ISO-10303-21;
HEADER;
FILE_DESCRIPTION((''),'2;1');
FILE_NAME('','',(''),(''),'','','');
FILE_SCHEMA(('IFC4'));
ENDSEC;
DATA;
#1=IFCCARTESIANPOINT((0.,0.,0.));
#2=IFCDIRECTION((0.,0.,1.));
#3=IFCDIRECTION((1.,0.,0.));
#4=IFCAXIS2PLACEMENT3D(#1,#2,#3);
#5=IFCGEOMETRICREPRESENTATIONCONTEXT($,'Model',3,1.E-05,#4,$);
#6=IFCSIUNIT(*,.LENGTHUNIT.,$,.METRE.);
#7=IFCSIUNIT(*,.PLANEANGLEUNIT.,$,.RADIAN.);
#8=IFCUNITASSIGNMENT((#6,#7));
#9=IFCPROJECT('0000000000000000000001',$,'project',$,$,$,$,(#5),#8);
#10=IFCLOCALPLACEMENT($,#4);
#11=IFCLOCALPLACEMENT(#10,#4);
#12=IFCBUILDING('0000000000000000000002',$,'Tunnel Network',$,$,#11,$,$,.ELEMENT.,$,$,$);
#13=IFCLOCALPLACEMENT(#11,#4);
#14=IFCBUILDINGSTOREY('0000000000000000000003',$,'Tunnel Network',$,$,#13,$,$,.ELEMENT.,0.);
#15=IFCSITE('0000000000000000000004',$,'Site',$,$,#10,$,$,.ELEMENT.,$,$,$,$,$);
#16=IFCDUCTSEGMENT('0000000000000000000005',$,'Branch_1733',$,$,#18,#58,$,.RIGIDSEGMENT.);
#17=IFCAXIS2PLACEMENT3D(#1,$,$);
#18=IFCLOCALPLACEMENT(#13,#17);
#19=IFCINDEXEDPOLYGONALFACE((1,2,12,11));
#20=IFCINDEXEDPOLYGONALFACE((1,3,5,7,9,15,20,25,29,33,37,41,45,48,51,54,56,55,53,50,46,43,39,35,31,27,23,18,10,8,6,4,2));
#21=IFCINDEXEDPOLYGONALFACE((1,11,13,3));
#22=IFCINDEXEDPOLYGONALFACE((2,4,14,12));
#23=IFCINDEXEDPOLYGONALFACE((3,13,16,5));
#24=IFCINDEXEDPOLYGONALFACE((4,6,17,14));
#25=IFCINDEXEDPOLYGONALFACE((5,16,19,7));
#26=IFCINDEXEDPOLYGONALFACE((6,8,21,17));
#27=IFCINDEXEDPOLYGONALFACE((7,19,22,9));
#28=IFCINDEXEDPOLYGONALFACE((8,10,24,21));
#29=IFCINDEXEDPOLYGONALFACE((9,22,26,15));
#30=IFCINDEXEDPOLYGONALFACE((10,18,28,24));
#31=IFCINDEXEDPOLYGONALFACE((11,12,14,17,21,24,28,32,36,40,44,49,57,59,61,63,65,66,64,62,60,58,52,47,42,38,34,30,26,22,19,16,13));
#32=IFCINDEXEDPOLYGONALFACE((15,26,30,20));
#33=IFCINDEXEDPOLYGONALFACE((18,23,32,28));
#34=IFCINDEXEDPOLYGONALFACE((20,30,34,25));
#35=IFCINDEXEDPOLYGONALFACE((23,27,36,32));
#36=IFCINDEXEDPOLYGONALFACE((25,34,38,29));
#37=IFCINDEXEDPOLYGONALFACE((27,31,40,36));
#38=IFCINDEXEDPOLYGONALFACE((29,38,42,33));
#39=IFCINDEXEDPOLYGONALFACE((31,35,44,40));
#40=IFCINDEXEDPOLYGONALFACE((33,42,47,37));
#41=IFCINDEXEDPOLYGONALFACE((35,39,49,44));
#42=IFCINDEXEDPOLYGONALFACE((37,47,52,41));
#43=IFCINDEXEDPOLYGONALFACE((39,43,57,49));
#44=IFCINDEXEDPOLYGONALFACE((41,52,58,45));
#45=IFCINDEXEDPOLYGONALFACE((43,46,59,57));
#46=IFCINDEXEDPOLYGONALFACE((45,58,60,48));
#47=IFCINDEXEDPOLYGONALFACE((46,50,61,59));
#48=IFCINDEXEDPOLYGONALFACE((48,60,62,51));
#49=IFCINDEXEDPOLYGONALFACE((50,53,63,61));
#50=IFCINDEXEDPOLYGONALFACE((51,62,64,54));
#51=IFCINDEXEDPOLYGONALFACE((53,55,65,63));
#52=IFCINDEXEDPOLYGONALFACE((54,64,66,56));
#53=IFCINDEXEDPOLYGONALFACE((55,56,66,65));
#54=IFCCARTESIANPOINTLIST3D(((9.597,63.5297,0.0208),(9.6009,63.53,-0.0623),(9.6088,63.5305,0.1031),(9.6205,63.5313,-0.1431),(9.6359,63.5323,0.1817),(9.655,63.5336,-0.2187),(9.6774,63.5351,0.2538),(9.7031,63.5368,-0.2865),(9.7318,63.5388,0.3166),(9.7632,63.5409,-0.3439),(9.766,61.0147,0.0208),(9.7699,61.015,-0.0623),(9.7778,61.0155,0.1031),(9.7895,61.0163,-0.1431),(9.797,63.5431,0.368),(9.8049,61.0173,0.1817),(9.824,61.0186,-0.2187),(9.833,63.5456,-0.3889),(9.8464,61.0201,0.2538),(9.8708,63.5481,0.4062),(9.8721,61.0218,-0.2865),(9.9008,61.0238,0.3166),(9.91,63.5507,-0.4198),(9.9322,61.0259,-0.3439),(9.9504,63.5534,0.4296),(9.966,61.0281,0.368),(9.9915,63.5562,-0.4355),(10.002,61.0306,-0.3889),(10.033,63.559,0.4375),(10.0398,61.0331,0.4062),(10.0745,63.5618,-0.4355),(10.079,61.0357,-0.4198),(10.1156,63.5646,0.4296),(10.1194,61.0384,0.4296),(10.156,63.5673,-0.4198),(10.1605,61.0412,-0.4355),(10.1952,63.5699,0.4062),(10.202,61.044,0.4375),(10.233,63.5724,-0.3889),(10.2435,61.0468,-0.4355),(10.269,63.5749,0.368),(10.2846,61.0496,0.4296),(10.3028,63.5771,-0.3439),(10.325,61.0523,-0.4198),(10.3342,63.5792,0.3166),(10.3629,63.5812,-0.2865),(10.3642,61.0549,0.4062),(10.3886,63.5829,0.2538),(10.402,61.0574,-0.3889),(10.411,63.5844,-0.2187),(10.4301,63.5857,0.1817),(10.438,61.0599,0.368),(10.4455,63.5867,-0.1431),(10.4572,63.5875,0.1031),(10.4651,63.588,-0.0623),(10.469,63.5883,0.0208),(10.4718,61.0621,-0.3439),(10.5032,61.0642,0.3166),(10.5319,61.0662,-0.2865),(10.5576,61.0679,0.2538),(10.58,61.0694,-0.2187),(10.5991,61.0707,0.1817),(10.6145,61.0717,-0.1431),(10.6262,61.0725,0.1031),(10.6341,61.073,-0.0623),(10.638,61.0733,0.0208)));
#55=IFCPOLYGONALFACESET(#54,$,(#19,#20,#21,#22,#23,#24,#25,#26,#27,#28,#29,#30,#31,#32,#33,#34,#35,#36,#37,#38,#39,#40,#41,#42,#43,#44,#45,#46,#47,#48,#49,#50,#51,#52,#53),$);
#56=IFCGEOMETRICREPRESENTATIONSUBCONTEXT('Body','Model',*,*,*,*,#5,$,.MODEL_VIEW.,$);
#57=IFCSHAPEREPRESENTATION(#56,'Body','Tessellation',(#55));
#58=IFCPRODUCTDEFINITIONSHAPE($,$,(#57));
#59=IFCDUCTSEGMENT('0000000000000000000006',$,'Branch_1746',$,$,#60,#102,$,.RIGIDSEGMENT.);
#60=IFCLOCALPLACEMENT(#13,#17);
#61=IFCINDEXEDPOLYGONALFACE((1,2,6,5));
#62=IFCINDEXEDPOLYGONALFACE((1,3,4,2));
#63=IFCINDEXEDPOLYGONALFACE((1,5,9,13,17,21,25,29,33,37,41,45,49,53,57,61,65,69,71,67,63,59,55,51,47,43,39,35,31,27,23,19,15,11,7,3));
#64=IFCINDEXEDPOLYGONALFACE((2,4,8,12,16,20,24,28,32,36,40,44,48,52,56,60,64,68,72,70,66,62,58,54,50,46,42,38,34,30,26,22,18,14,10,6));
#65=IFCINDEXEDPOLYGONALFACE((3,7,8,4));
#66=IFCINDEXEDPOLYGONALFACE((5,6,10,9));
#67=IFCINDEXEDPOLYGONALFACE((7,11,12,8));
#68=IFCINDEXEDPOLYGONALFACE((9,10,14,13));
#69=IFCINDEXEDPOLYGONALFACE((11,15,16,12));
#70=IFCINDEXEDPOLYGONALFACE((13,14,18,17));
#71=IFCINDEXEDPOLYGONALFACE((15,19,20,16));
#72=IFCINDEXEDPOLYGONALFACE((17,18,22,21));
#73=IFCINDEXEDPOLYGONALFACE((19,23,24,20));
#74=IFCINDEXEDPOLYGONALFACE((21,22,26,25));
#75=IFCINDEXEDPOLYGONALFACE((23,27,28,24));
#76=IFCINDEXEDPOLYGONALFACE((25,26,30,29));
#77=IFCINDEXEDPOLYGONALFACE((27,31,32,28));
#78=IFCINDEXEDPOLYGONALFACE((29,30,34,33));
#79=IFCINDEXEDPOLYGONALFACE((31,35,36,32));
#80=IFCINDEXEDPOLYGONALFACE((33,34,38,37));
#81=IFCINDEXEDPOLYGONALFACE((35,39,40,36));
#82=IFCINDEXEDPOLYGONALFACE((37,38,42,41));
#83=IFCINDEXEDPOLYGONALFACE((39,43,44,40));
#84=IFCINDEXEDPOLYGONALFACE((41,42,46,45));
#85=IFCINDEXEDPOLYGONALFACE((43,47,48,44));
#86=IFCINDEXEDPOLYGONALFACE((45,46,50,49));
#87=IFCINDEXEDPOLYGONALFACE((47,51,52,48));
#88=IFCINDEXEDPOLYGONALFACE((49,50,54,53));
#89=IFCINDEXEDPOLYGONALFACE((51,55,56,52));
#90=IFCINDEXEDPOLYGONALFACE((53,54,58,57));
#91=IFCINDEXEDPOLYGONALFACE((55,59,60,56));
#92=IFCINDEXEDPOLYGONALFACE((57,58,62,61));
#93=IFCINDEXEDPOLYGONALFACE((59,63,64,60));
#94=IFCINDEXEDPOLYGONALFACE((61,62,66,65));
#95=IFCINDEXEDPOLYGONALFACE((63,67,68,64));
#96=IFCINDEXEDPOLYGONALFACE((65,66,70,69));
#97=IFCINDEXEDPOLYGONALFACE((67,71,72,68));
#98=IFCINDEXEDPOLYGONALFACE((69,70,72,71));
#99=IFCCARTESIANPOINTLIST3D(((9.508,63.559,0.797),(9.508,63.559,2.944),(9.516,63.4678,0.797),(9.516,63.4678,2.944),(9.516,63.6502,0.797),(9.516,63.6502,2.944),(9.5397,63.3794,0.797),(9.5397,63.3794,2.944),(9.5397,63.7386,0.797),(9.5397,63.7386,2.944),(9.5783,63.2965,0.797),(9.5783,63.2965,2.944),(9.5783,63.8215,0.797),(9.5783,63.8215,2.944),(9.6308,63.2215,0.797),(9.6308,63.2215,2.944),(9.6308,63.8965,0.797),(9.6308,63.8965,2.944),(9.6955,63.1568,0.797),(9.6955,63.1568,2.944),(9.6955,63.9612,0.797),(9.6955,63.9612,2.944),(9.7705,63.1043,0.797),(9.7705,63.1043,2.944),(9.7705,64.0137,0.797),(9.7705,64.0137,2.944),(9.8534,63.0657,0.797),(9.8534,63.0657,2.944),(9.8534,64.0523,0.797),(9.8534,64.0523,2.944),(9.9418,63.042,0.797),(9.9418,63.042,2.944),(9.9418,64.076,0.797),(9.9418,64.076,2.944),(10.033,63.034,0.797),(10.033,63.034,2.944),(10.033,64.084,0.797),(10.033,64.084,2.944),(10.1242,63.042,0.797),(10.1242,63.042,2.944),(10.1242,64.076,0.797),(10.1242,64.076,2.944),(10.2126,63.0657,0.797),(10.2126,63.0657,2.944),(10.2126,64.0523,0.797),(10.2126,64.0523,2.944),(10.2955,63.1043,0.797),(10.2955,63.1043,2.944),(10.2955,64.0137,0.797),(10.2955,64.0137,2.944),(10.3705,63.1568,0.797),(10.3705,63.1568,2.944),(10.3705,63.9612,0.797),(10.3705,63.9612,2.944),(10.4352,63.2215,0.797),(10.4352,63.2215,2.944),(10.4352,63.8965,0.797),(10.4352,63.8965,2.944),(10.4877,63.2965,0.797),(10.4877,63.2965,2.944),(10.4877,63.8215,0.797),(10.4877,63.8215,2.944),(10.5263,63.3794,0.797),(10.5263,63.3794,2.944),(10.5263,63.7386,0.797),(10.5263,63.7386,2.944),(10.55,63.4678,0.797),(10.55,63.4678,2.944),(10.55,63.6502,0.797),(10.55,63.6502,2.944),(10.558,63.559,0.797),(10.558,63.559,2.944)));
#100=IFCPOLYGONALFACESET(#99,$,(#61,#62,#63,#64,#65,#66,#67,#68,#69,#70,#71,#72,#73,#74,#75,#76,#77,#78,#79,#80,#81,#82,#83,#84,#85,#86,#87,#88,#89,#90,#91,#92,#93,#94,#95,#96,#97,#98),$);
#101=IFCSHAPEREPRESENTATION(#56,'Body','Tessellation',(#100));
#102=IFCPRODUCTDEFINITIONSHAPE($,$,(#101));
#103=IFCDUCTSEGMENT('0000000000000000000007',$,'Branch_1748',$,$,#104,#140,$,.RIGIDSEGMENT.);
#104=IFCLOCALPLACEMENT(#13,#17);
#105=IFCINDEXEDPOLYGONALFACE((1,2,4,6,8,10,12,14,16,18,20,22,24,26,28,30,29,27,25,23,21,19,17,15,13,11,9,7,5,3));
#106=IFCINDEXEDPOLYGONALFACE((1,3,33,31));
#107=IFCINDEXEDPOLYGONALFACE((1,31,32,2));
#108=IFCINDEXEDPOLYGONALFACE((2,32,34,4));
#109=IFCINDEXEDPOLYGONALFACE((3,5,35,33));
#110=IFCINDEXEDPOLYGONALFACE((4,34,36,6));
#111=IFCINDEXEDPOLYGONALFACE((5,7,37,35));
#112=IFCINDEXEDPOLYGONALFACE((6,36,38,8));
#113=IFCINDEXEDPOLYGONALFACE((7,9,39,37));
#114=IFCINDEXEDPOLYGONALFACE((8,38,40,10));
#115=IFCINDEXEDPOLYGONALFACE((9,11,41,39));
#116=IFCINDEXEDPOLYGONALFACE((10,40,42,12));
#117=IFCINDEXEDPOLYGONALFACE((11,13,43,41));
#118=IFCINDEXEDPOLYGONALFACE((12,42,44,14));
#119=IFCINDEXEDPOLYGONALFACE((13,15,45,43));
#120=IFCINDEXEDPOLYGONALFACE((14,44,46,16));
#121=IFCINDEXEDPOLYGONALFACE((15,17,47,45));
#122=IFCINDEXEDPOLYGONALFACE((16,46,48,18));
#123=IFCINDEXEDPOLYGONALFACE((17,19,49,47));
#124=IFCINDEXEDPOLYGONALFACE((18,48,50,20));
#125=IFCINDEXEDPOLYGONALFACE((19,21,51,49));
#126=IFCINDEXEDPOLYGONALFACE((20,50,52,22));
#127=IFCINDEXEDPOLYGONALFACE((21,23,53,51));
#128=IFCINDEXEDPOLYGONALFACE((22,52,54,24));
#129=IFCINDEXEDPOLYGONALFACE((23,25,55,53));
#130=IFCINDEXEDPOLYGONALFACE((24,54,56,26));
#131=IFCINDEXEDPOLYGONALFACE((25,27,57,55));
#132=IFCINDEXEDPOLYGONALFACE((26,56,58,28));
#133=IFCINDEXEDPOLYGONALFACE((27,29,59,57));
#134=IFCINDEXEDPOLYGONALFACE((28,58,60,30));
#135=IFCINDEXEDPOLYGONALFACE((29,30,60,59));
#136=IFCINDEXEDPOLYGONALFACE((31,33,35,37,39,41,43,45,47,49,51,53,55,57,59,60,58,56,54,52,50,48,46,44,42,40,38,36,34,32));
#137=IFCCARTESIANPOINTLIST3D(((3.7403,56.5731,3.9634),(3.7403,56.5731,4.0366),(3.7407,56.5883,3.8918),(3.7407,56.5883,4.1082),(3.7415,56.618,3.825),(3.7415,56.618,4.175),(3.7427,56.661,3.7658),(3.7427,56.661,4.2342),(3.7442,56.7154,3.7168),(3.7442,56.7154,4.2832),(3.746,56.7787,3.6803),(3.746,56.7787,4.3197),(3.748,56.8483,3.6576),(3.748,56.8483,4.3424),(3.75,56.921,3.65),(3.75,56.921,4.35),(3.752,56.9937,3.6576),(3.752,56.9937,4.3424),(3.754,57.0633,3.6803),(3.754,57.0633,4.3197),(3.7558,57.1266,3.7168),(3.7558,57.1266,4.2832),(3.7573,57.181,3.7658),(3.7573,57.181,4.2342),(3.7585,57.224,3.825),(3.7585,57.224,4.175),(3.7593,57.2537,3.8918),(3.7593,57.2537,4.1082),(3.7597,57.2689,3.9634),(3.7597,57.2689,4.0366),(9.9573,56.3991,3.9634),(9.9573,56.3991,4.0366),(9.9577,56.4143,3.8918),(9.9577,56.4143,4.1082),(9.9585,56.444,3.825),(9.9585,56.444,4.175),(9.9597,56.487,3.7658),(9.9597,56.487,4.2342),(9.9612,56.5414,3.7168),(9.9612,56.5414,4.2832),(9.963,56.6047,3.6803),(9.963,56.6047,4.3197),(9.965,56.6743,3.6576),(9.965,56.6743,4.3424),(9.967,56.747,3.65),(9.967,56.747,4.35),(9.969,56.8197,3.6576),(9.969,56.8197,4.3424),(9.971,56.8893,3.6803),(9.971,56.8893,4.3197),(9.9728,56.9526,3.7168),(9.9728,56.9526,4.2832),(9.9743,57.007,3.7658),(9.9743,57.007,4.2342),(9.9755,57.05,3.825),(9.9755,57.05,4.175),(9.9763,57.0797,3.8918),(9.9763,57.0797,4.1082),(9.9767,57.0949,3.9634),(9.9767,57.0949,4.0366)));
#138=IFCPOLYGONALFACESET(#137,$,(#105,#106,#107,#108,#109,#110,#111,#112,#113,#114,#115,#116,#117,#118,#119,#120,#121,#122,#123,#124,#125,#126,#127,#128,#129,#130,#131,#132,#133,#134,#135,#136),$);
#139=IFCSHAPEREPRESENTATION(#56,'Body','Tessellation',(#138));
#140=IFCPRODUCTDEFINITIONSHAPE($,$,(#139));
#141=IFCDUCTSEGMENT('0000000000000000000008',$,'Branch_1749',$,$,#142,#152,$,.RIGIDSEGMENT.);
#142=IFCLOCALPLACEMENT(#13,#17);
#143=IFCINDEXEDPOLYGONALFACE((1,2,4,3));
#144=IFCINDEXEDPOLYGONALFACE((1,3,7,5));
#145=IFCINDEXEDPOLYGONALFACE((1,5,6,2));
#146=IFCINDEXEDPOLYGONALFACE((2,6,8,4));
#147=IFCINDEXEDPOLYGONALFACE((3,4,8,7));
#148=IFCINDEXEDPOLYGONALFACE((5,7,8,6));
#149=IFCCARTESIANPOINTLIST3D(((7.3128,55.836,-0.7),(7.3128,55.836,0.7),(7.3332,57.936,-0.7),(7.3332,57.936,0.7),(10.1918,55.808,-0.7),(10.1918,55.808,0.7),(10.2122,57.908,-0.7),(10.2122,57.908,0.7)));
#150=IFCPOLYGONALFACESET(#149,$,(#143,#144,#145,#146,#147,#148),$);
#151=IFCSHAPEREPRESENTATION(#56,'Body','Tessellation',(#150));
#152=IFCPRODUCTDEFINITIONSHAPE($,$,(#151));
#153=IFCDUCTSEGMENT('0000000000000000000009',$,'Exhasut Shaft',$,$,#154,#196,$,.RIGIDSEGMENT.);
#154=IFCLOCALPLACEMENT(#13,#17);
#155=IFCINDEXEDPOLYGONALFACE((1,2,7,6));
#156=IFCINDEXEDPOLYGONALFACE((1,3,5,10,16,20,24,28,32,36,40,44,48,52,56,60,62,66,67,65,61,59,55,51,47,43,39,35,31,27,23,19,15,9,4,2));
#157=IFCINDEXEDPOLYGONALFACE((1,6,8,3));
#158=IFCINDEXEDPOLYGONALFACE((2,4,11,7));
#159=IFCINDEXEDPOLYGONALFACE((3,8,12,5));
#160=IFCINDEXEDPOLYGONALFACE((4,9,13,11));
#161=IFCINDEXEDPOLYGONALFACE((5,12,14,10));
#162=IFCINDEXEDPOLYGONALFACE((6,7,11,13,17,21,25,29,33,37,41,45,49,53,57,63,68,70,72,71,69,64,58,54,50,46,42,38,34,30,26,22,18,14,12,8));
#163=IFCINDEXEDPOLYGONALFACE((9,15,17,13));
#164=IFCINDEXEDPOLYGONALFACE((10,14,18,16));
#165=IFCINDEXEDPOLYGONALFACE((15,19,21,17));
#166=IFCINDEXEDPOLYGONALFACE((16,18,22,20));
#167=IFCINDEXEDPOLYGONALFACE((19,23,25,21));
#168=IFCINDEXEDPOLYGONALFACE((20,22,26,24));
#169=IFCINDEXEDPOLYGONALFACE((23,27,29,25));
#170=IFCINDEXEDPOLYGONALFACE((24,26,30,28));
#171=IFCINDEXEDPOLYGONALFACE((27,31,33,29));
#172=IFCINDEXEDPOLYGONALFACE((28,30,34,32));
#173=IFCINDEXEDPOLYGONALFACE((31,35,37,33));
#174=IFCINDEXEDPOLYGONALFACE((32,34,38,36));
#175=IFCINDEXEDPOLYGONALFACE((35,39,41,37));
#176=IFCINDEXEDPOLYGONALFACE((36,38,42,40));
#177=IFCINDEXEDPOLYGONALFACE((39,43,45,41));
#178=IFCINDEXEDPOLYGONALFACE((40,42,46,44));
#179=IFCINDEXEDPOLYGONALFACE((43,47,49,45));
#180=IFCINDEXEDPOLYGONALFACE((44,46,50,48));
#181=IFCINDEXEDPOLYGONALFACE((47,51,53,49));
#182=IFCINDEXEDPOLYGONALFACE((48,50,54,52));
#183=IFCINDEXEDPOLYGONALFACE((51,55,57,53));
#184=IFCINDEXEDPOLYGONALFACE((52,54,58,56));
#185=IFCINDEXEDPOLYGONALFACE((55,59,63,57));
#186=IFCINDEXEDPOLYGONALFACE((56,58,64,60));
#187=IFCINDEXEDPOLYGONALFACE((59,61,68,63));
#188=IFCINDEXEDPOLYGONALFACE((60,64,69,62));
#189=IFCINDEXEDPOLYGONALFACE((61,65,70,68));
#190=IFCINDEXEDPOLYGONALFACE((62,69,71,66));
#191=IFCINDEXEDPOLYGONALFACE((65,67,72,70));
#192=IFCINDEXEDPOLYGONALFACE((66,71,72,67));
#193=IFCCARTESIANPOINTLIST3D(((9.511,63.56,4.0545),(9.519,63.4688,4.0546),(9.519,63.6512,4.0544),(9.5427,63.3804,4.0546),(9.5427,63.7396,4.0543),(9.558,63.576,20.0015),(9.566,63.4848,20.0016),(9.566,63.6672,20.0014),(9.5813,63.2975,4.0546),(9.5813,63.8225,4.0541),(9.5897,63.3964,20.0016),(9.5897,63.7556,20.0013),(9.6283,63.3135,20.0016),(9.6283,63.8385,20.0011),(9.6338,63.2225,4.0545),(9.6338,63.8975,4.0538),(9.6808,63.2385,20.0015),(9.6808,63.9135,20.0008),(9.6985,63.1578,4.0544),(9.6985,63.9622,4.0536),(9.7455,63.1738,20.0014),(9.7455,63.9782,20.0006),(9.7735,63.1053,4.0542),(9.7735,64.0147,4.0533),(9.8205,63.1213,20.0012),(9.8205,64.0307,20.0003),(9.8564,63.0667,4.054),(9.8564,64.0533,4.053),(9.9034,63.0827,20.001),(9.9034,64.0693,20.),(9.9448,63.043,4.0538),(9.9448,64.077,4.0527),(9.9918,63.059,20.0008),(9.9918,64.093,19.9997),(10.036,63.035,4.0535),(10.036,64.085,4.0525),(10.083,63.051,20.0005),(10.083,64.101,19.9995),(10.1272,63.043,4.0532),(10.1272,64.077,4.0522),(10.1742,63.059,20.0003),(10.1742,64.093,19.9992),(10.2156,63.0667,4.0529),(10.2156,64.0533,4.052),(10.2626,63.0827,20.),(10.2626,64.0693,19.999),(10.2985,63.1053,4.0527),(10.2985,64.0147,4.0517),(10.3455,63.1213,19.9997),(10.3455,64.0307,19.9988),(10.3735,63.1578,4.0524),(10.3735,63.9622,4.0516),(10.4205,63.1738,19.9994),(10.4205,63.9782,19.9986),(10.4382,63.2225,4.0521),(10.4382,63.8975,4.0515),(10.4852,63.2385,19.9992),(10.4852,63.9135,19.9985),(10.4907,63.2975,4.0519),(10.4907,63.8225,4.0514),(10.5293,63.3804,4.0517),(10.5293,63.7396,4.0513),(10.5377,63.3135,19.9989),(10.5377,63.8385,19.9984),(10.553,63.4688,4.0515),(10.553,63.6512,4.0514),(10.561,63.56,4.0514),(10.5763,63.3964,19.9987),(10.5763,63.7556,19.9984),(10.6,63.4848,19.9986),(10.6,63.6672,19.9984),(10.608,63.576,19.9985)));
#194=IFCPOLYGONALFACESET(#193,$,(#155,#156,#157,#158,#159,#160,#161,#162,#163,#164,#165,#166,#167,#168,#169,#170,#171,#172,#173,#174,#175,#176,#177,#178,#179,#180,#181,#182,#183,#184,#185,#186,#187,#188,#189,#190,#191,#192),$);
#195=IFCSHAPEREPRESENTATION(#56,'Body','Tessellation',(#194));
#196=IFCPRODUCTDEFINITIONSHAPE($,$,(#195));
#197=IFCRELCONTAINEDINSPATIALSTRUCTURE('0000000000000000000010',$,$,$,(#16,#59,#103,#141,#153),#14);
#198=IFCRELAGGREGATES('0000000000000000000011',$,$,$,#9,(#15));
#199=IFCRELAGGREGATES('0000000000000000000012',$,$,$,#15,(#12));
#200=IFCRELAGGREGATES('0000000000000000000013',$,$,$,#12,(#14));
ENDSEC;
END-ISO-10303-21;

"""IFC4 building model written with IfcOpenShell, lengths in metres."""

from ifc_helpers import new_model, si_unit, frame, origin_with_axes, origin_2d_with_axis, place, context, subcontext, project, spatial, rectangle, circle, extrude, element, save


model = new_model("IFC4")

# Units and contexts
model_context = context("Model", 3, precision=1e-05, world=origin_with_axes())
body_context = subcontext(model_context, "Body", "Model", "MODEL_VIEW")
ifc_project = project(units=[si_unit("LENGTHUNIT", "METRE"), si_unit("PLANEANGLEUNIT", "RADIAN")], contexts=[model_context])

# Site, building, storey
site_placement = place(None, origin_with_axes())
site = spatial("IfcSite", under=ifc_project, at=site_placement, Name="Site", CompositionType="ELEMENT")
building_placement = place(site_placement, origin_with_axes())
building = spatial("IfcBuilding", under=site, at=building_placement, Name="Tunnel Network", CompositionType="ELEMENT")
storey_placement = place(building_placement, origin_with_axes())
storey = spatial("IfcBuildingStorey", under=building, at=storey_placement, Name="Tunnel Network", CompositionType="ELEMENT", Elevation=0.0)

# Duct segments
duct_segment_1_placement = place(storey_placement, frame((10.202, 61.044, 0.0), z_axis=(-0.067045, 0.99775, 0.0), x_axis=(0.0, 0.0, 1.0)))
element("IfcDuctSegment", 1, at=duct_segment_1_placement, inside=storey, Name="Branch_1733", PredefinedType="RIGIDSEGMENT", context=body_context, shape_type="SweptSolid", body=[
    extrude(circle(Radius=0.4375, at=origin_2d_with_axis()), origin_with_axes(), (0.0, 0.0, 1.0), 2.5207),
])
duct_segment_2_placement = place(storey_placement, frame((10.033, 63.559, 0.797), z_axis=(0.0, 0.0, 1.0), x_axis=(1.0, 0.0, 0.0)))
element("IfcDuctSegment", 2, at=duct_segment_2_placement, inside=storey, Name="Branch_1746", PredefinedType="RIGIDSEGMENT", context=body_context, shape_type="SweptSolid", body=[
    extrude(circle(Radius=0.525, at=origin_2d_with_axis()), origin_with_axes(), (0.0, 0.0, 1.0), 2.147),
])
duct_segment_3_placement = place(storey_placement, frame((3.75, 56.921, 4.0), z_axis=(0.999609, -0.027977, 0.0), x_axis=(0.0, 0.0, 1.0)))
element("IfcDuctSegment", 3, at=duct_segment_3_placement, inside=storey, Name="Branch_1748", PredefinedType="RIGIDSEGMENT", context=body_context, shape_type="SweptSolid", body=[
    extrude(circle(Radius=0.35, at=origin_2d_with_axis()), origin_with_axes(), (0.0, 0.0, 1.0), 6.2194),
])
duct_segment_4_placement = place(storey_placement, frame((7.323, 56.886, 0.0), z_axis=(0.999953, -0.009725, 0.0), x_axis=(0.0, 0.0, 1.0)))
element("IfcDuctSegment", 4, at=duct_segment_4_placement, inside=storey, Name="Branch_1749", PredefinedType="RIGIDSEGMENT", context=body_context, shape_type="SweptSolid", body=[
    extrude(rectangle(XDim=1.4, YDim=2.1, at=origin_2d_with_axis()), origin_with_axes(), (0.0, 0.0, 1.0), 2.8791),
])
duct_segment_5_placement = place(storey_placement, frame((10.036, 63.56, 4.053), z_axis=(0.002947, 0.001003, 0.999995), x_axis=(0.999996, -0.000003, -0.002947)))
element("IfcDuctSegment", 5, at=duct_segment_5_placement, inside=storey, Name="Exhasut Shaft", PredefinedType="RIGIDSEGMENT", context=body_context, shape_type="SweptSolid", body=[
    extrude(circle(Radius=0.525, at=origin_2d_with_axis()), origin_with_axes(), (0.0, 0.0, 1.0), 15.9471),
])

save(model, "model.ifc")
